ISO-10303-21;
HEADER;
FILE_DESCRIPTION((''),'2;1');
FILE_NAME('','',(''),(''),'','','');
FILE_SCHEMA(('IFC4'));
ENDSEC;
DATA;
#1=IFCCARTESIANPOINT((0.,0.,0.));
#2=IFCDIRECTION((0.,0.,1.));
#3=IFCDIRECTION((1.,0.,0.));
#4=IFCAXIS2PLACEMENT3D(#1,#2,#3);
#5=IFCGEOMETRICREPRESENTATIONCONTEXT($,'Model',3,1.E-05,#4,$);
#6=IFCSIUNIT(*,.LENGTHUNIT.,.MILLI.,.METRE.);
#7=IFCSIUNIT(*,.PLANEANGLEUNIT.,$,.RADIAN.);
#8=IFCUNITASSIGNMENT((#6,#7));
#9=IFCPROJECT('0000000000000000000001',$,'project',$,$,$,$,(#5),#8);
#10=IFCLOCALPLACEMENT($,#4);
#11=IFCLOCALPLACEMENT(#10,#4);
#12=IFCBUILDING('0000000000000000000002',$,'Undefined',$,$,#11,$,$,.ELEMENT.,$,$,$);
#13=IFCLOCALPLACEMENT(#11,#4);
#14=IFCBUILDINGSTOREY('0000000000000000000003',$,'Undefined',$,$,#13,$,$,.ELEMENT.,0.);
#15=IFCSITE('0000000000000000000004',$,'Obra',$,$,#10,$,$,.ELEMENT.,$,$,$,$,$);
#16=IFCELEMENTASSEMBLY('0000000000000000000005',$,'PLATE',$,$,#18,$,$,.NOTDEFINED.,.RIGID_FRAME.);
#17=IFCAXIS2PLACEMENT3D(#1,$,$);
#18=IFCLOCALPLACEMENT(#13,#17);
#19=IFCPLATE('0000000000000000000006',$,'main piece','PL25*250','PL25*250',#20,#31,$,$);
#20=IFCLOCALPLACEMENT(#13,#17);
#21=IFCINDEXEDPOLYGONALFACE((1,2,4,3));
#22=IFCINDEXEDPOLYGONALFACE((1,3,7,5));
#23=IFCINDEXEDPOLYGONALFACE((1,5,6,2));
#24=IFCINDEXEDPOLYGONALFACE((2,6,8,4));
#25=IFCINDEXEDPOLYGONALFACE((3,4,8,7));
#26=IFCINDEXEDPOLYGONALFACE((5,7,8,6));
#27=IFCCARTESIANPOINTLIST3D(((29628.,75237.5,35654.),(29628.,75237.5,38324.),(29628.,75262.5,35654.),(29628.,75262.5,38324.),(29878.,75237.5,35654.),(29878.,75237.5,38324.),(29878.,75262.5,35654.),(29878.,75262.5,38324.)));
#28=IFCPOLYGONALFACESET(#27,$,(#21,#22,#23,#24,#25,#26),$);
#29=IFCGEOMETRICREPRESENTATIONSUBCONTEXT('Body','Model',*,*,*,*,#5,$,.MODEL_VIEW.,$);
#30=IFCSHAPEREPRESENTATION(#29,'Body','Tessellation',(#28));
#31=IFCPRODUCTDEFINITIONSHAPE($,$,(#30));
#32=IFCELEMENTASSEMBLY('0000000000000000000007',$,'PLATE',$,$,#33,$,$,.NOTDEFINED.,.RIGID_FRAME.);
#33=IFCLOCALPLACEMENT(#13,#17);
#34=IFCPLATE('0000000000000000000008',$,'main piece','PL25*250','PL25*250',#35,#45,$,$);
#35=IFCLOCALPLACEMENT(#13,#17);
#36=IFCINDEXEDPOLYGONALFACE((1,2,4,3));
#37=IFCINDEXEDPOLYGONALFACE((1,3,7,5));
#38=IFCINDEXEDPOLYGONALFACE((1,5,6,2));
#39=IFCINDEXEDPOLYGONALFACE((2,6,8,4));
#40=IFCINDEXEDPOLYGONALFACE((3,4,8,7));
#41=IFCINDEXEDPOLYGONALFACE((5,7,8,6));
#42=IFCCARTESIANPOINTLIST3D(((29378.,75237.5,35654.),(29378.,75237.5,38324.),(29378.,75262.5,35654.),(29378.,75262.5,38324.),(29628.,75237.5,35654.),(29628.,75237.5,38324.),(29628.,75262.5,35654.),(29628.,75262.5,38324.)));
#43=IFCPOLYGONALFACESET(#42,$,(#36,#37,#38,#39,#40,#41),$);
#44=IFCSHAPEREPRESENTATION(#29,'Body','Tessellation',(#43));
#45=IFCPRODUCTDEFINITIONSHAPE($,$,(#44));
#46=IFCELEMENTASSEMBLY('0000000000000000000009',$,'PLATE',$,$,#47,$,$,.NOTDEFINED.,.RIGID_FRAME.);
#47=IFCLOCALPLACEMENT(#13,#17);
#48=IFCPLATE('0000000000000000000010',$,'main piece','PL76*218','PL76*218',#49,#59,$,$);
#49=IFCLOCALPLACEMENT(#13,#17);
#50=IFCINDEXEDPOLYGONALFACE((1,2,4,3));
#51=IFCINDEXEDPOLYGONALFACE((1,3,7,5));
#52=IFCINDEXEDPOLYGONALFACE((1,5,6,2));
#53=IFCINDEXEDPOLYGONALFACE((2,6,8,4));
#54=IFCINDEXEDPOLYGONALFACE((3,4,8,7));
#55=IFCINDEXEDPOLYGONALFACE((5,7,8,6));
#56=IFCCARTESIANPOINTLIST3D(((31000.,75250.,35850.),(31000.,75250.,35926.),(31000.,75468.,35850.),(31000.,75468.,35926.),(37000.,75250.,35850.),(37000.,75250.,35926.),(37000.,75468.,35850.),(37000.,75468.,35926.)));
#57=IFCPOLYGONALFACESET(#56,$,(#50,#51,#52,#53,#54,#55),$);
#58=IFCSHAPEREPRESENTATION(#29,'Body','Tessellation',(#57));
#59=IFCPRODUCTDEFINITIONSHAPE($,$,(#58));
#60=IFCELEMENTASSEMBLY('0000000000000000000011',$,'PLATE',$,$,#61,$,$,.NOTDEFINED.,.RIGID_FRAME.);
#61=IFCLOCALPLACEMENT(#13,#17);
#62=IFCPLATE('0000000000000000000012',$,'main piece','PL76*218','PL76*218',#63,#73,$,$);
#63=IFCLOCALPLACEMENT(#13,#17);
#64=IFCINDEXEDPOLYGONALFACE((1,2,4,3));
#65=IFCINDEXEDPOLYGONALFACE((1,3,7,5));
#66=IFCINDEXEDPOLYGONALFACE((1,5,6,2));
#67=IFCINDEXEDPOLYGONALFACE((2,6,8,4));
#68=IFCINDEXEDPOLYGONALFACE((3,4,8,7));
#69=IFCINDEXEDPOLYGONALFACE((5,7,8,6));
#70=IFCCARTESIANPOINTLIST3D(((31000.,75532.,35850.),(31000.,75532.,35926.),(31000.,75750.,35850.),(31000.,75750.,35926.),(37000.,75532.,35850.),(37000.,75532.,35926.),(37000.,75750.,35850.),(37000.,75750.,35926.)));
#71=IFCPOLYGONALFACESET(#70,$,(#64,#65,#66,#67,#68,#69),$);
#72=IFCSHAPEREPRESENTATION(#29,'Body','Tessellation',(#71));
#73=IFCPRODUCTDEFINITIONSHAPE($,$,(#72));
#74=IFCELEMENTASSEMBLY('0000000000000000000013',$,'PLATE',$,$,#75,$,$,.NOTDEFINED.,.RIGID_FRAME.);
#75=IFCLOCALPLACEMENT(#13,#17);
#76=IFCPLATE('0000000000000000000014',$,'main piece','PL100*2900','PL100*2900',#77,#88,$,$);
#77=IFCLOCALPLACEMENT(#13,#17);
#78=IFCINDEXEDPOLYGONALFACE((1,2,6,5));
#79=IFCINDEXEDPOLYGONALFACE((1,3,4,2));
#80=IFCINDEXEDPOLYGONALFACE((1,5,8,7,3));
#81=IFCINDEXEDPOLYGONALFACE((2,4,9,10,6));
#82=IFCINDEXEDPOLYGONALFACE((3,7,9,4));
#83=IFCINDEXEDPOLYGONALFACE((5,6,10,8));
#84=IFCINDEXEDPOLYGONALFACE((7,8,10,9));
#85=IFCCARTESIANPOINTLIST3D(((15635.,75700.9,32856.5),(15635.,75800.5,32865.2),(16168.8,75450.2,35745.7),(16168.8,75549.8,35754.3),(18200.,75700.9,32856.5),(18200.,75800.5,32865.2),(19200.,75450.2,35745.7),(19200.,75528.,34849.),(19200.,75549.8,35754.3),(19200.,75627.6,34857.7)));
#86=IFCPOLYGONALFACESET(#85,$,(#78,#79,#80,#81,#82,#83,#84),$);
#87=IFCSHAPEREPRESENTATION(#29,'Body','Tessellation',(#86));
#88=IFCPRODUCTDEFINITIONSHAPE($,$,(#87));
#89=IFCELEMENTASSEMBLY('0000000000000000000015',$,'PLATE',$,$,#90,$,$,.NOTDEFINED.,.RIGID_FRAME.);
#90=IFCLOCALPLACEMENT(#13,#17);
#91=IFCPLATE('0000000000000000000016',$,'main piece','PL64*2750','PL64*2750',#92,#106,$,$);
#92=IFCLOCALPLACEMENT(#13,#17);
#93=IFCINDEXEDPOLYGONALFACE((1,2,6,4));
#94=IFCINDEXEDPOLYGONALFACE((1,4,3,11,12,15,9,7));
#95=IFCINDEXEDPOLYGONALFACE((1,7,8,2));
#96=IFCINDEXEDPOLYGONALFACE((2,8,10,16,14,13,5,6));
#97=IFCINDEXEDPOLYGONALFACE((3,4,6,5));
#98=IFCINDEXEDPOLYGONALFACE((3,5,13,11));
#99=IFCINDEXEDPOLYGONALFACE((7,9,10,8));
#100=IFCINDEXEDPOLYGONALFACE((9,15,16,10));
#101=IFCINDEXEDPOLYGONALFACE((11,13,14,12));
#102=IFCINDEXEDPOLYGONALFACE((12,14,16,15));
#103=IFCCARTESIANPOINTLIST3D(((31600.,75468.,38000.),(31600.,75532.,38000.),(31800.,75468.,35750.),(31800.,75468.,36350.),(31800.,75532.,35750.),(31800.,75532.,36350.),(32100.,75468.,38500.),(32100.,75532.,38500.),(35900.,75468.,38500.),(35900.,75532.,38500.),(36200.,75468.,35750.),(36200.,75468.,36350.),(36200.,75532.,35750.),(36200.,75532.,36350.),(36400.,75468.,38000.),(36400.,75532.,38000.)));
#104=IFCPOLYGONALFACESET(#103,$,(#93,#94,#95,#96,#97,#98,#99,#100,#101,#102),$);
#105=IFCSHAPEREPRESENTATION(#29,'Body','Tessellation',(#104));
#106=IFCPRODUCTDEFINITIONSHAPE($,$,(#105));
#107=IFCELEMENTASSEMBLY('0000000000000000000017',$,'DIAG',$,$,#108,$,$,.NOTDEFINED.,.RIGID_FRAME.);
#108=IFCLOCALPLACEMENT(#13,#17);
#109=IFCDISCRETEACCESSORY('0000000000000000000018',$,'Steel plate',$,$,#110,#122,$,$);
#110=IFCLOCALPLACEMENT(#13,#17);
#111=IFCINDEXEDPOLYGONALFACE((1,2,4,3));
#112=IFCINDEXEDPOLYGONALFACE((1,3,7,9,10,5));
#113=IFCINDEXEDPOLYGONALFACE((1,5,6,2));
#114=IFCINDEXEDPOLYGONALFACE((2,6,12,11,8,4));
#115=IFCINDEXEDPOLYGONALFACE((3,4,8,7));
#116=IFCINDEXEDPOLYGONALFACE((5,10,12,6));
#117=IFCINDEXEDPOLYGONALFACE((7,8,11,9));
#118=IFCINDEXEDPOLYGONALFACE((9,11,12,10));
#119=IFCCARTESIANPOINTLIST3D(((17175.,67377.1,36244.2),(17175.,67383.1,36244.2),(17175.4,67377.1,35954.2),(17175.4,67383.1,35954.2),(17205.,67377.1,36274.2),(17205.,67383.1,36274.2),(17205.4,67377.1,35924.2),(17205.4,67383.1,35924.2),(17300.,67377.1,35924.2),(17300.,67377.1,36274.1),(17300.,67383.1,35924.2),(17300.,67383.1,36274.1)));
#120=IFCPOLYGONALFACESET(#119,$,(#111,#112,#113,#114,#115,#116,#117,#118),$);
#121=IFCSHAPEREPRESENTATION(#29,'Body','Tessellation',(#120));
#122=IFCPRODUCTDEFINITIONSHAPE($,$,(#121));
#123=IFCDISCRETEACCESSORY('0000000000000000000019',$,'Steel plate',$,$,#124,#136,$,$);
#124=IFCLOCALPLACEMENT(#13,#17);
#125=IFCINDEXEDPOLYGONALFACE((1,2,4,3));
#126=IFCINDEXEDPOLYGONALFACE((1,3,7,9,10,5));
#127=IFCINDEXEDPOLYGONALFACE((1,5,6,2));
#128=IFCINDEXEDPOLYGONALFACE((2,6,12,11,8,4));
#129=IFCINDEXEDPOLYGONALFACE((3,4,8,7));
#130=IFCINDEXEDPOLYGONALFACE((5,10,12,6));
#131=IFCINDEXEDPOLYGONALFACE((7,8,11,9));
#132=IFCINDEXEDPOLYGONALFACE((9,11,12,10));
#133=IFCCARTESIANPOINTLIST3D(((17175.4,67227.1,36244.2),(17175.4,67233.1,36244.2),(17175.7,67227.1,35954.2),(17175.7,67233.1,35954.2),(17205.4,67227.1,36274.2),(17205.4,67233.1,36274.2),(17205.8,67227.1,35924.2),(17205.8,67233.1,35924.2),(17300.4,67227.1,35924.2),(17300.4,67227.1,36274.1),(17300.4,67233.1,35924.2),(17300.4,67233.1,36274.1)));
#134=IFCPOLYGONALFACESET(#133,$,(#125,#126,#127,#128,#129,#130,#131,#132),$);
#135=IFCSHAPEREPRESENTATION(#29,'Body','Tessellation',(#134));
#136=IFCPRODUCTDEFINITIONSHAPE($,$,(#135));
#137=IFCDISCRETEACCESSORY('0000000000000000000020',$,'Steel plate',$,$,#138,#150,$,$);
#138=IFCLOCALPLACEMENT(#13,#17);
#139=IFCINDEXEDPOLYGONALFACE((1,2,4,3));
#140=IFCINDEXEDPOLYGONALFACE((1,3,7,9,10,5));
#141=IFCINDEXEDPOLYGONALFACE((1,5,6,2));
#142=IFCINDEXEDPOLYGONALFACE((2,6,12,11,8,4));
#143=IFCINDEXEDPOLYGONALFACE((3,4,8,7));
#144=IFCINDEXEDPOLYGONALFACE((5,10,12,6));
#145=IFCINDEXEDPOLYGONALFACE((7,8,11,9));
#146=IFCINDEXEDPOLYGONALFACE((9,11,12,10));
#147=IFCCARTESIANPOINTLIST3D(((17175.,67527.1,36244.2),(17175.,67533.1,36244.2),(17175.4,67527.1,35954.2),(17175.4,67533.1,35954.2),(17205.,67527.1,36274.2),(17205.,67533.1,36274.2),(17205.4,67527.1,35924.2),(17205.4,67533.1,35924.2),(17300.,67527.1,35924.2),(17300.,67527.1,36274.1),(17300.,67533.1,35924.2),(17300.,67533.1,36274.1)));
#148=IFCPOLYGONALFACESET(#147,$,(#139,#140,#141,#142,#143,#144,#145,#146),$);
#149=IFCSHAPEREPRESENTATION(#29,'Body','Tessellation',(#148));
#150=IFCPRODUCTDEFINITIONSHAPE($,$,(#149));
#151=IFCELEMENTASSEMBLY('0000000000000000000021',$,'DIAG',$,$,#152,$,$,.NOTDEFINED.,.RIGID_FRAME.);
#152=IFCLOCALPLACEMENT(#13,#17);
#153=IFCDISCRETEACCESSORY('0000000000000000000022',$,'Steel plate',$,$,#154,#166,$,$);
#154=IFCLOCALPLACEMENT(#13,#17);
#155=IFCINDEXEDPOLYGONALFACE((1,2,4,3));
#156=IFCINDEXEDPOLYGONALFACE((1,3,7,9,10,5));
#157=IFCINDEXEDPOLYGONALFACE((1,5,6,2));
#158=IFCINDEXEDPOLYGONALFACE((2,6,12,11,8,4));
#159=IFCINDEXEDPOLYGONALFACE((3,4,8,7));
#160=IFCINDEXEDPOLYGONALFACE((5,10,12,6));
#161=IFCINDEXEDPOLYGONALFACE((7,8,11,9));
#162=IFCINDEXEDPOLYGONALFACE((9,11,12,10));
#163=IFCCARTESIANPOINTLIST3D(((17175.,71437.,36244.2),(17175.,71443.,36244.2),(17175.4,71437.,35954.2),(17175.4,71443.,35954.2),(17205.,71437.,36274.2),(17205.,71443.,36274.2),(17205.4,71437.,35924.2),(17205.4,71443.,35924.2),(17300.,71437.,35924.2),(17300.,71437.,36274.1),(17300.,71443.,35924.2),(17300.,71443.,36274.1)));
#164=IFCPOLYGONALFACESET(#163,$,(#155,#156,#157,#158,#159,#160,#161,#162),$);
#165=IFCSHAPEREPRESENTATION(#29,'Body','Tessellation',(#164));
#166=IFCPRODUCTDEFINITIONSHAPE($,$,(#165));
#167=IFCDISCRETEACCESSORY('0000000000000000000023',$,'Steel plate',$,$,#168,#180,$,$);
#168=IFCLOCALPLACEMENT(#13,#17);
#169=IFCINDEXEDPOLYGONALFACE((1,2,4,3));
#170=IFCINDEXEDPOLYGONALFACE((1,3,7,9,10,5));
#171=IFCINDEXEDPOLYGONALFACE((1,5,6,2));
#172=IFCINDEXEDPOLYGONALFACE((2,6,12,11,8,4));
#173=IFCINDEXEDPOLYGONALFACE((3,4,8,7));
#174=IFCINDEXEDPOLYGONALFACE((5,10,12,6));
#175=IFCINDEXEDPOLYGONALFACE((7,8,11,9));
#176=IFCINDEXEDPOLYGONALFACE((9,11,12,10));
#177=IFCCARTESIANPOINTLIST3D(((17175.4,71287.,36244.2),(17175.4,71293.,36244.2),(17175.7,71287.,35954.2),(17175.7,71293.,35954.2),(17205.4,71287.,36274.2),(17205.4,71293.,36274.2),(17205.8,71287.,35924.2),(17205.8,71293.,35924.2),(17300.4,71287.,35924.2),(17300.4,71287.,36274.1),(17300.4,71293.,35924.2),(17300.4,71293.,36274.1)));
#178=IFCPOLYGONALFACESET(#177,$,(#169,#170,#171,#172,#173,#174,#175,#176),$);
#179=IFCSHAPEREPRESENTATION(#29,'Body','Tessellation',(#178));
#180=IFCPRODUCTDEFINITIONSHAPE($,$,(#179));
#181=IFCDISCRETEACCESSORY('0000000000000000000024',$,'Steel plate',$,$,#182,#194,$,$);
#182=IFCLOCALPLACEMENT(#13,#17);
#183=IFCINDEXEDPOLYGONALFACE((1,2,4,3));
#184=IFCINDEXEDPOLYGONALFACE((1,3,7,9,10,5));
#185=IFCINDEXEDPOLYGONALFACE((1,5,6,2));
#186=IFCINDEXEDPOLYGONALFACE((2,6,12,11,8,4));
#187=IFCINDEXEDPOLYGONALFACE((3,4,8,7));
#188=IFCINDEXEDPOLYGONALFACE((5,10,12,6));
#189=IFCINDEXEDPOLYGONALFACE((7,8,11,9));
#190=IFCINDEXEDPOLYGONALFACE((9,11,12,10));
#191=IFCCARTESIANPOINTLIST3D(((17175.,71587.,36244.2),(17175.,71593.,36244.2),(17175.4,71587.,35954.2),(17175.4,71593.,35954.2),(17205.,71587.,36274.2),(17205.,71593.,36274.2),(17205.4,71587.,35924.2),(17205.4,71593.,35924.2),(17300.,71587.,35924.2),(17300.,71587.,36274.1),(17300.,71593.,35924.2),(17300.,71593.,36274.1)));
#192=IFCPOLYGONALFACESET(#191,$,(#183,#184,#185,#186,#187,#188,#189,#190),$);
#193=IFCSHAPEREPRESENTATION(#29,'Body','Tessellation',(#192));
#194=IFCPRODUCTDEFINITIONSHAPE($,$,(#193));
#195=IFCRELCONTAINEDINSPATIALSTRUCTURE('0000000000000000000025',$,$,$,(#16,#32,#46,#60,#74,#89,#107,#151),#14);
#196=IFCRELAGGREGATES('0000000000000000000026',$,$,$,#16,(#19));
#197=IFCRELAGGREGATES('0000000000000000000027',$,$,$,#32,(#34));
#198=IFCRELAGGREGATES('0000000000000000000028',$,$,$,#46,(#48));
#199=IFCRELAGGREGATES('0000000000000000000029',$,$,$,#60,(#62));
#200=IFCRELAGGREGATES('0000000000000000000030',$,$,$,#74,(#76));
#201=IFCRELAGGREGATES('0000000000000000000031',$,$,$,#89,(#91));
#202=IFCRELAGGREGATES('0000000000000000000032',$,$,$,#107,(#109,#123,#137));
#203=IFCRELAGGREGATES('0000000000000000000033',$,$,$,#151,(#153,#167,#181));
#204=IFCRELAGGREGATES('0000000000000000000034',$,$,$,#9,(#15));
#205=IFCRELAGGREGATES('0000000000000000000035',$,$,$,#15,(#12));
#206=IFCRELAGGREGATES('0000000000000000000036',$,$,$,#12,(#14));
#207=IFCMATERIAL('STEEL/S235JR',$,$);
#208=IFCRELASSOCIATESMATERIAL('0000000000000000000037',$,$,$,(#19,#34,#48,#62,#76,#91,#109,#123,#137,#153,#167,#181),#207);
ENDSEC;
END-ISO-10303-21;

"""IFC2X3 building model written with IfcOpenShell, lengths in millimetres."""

from ifc_helpers import new_model, si_unit, frame, origin_with_axes, place, context, subcontext, project, spatial, polyline, outline, extrude, material, element, aggregate, save


model = new_model("IFC2X3")

# Units and contexts
model_context = context("Model", 3, precision=1e-05, world=origin_with_axes())
body_context = subcontext(model_context, "Body", "Model", "MODEL_VIEW")
ifc_project = project(units=[si_unit("LENGTHUNIT", "METRE", prefix="MILLI"), si_unit("PLANEANGLEUNIT", "RADIAN")], contexts=[model_context])

# Site, building, storey
site_placement = place(None, origin_with_axes())
site = spatial("IfcSite", under=ifc_project, at=site_placement, Name="Obra", CompositionType="ELEMENT")
building_placement = place(site_placement, origin_with_axes())
building = spatial("IfcBuilding", under=site, at=building_placement, Name="Undefined", CompositionType="ELEMENT")
storey_placement = place(building_placement, origin_with_axes())
storey = spatial("IfcBuildingStorey", under=building, at=storey_placement, Name="Undefined", CompositionType="ELEMENT", Elevation=0.0)

# Shared definitions
ifc_material = material(Name="STEEL/S235JR")

# Element assemblies, plates
assembly_1_placement = place(storey_placement, origin_with_axes())
assembly_1 = element("IfcElementAssembly", 1, at=assembly_1_placement, inside=storey, Name="PLATE", AssemblyPlace="NOTDEFINED", PredefinedType="RIGID_FRAME")
plate_1_placement = place(assembly_1_placement, frame((29628.0, 75250.0, 35654.0), z_axis=(0.0, -1.0, 0.0), x_axis=(1.0, 0.0, 0.0)))
plate_1 = element("IfcPlate", 2, at=plate_1_placement, material=ifc_material, Name="main piece", Description="PL25*250", ObjectType="PL25*250", context=body_context, shape_type="SweptSolid", body=[
    extrude(outline(polyline([(0.0, 0.0), (250.0, 0.0), (250.0, 2670.0), (0.0, 2670.0), (0.0, 0.0)])), frame((0.0, 0.0, -12.5), z_axis=(0.0, 0.0, 1.0), x_axis=(1.0, 0.0, 0.0)), (0.0, 0.0, 1.0), 25.0),
])
aggregate(assembly_1, [plate_1])
assembly_2_placement = place(storey_placement, origin_with_axes())
assembly_2 = element("IfcElementAssembly", 3, at=assembly_2_placement, inside=storey, Name="PLATE", AssemblyPlace="NOTDEFINED", PredefinedType="RIGID_FRAME")
plate_2_placement = place(assembly_2_placement, frame((29378.0, 75250.0, 35654.0), z_axis=(0.0, -1.0, 0.0), x_axis=(1.0, 0.0, 0.0)))
plate_2 = element("IfcPlate", 4, at=plate_2_placement, material=ifc_material, Name="main piece", Description="PL25*250", ObjectType="PL25*250", context=body_context, shape_type="SweptSolid", body=[
    extrude(outline(polyline([(0.0, 0.0), (250.0, 0.0), (250.0, 2670.0), (0.0, 2670.0), (0.0, 0.0)])), frame((0.0, 0.0, -12.5), z_axis=(0.0, 0.0, 1.0), x_axis=(1.0, 0.0, 0.0)), (0.0, 0.0, 1.0), 25.0),
])
aggregate(assembly_2, [plate_2])
assembly_3_placement = place(storey_placement, origin_with_axes())
assembly_3 = element("IfcElementAssembly", 5, at=assembly_3_placement, inside=storey, Name="PLATE", AssemblyPlace="NOTDEFINED", PredefinedType="RIGID_FRAME")
plate_3_placement = place(assembly_3_placement, frame((31000.0, 75250.0, 35888.0), z_axis=(0.0, 0.0, -1.0), x_axis=(0.0, 1.0, 0.0)))
plate_3 = element("IfcPlate", 6, at=plate_3_placement, material=ifc_material, Name="main piece", Description="PL76*218", ObjectType="PL76*218", context=body_context, shape_type="SweptSolid", body=[
    extrude(outline(polyline([(0.0, 0.0), (218.0, 0.0), (218.0, 6000.0), (0.0, 6000.0), (0.0, 0.0)])), frame((0.0, 0.0, -38.0), z_axis=(0.0, 0.0, 1.0), x_axis=(1.0, 0.0, 0.0)), (0.0, 0.0, 1.0), 76.0),
])
aggregate(assembly_3, [plate_3])
assembly_4_placement = place(storey_placement, origin_with_axes())
assembly_4 = element("IfcElementAssembly", 7, at=assembly_4_placement, inside=storey, Name="PLATE", AssemblyPlace="NOTDEFINED", PredefinedType="RIGID_FRAME")
plate_4_placement = place(assembly_4_placement, frame((31000.0, 75750.0, 35888.0), z_axis=(0.0, 0.0, 1.0), x_axis=(0.0, -1.0, 0.0)))
plate_4 = element("IfcPlate", 8, at=plate_4_placement, material=ifc_material, Name="main piece", Description="PL76*218", ObjectType="PL76*218", context=body_context, shape_type="SweptSolid", body=[
    extrude(outline(polyline([(0.0, 0.0), (218.0, 0.0), (218.0, 6000.0), (0.0, 6000.0), (0.0, 0.0)])), frame((0.0, 0.0, -38.0), z_axis=(0.0, 0.0, 1.0), x_axis=(1.0, 0.0, 0.0)), (0.0, 0.0, 1.0), 76.0),
])
aggregate(assembly_4, [plate_4])
assembly_5_placement = place(storey_placement, origin_with_axes())
assembly_5 = element("IfcElementAssembly", 9, at=assembly_5_placement, inside=storey, Name="PLATE", AssemblyPlace="NOTDEFINED", PredefinedType="RIGID_FRAME")
plate_5_placement = place(assembly_5_placement, frame((19200.0, 75500.0, 35750.0), z_axis=(0.0, -0.996255, -0.08646), x_axis=(-1.0, 0.0, 0.0)))
plate_5 = element("IfcPlate", 10, at=plate_5_placement, material=ifc_material, Name="main piece", Description="PL100*2900", ObjectType="PL100*2900", context=body_context, shape_type="SweptSolid", body=[
    extrude(outline(polyline([(0.0, 0.0), (3031.2, 0.0), (3565.0, 2900.0), (1000.0, 2900.0), (0.0, 900.0), (0.0, 0.0)])), frame((0.0, 0.0, -50.0), z_axis=(0.0, 0.0, 1.0), x_axis=(1.0, 0.0, 0.0)), (0.0, 0.0, 1.0), 100.0),
])
aggregate(assembly_5, [plate_5])
assembly_6_placement = place(storey_placement, origin_with_axes())
assembly_6 = element("IfcElementAssembly", 11, at=assembly_6_placement, inside=storey, Name="PLATE", AssemblyPlace="NOTDEFINED", PredefinedType="RIGID_FRAME")
plate_6_placement = place(assembly_6_placement, frame((31800.0, 75500.0, 35750.0), z_axis=(0.0, -1.0, 0.0), x_axis=(1.0, 0.0, 0.0)))
plate_6 = element("IfcPlate", 12, at=plate_6_placement, material=ifc_material, Name="main piece", Description="PL64*2750", ObjectType="PL64*2750", context=body_context, shape_type="SweptSolid", body=[
    extrude(outline(polyline([(0.0, 0.0), (4400.0, 0.0), (4400.0, 600.0), (4600.0, 2250.0), (4100.0, 2750.0), (300.0, 2750.0), (-200.0, 2250.0), (0.0, 600.0), (0.0, 0.0)])), frame((0.0, 0.0, -32.0), z_axis=(0.0, 0.0, 1.0), x_axis=(1.0, 0.0, 0.0)), (0.0, 0.0, 1.0), 64.0),
])
aggregate(assembly_6, [plate_6])

# Element assemblies, discrete accessories
assembly_7_placement = place(storey_placement, origin_with_axes())
assembly_7 = element("IfcElementAssembly", 13, at=assembly_7_placement, inside=storey, Name="DIAG", AssemblyPlace="NOTDEFINED", PredefinedType="RIGID_FRAME")
discrete_accessory_1_placement = place(assembly_7_placement, frame((17300.0, 67380.1, 35924.2), z_axis=(0.0, 1.0, 0.0), x_axis=(-1.0, 0.0, 0.0)))
discrete_accessory_1 = element("IfcDiscreteAccessory", 14, at=discrete_accessory_1_placement, material=ifc_material, Name="Steel plate", context=body_context, shape_type="SweptSolid", body=[
    extrude(outline(polyline([(0.0, 0.0), (94.6, 0.0), (124.6, 30.0), (125.0, 320.0), (95.0, 350.0), (0.0, 349.9), (0.0, 0.0)])), frame((0.0, 0.0, -3.0), z_axis=(0.0, 0.0, 1.0), x_axis=(1.0, 0.0, 0.0)), (0.0, 0.0, 1.0), 6.0),
])
discrete_accessory_2_placement = place(assembly_7_placement, frame((17300.4, 67230.1, 35924.2), z_axis=(0.0, 1.0, 0.0), x_axis=(-1.0, 0.0, 0.0)))
discrete_accessory_2 = element("IfcDiscreteAccessory", 15, at=discrete_accessory_2_placement, material=ifc_material, Name="Steel plate", context=body_context, shape_type="SweptSolid", body=[
    extrude(outline(polyline([(0.0, 0.0), (94.6, 0.0), (124.6, 30.0), (125.0, 320.0), (95.0, 350.0), (0.0, 349.9), (0.0, 0.0)])), frame((0.0, 0.0, -3.0), z_axis=(0.0, 0.0, 1.0), x_axis=(1.0, 0.0, 0.0)), (0.0, 0.0, 1.0), 6.0),
])
discrete_accessory_3_placement = place(assembly_7_placement, frame((17300.0, 67530.1, 35924.2), z_axis=(0.0, 1.0, 0.0), x_axis=(-1.0, 0.0, 0.0)))
discrete_accessory_3 = element("IfcDiscreteAccessory", 16, at=discrete_accessory_3_placement, material=ifc_material, Name="Steel plate", context=body_context, shape_type="SweptSolid", body=[
    extrude(outline(polyline([(0.0, 0.0), (94.6, 0.0), (124.6, 30.0), (125.0, 320.0), (95.0, 350.0), (0.0, 349.9), (0.0, 0.0)])), frame((0.0, 0.0, -3.0), z_axis=(0.0, 0.0, 1.0), x_axis=(1.0, 0.0, 0.0)), (0.0, 0.0, 1.0), 6.0),
])
aggregate(assembly_7, [discrete_accessory_1, discrete_accessory_2, discrete_accessory_3])
assembly_8_placement = place(storey_placement, origin_with_axes())
assembly_8 = element("IfcElementAssembly", 17, at=assembly_8_placement, inside=storey, Name="DIAG", AssemblyPlace="NOTDEFINED", PredefinedType="RIGID_FRAME")
discrete_accessory_4_placement = place(assembly_8_placement, frame((17300.0, 71440.0, 35924.2), z_axis=(0.0, 1.0, 0.0), x_axis=(-1.0, 0.0, 0.0)))
discrete_accessory_4 = element("IfcDiscreteAccessory", 18, at=discrete_accessory_4_placement, material=ifc_material, Name="Steel plate", context=body_context, shape_type="SweptSolid", body=[
    extrude(outline(polyline([(0.0, 0.0), (94.6, 0.0), (124.6, 30.0), (125.0, 320.0), (95.0, 350.0), (0.0, 349.9), (0.0, 0.0)])), frame((0.0, 0.0, -3.0), z_axis=(0.0, 0.0, 1.0), x_axis=(1.0, 0.0, 0.0)), (0.0, 0.0, 1.0), 6.0),
])
discrete_accessory_5_placement = place(assembly_8_placement, frame((17300.4, 71290.0, 35924.2), z_axis=(0.0, 1.0, 0.0), x_axis=(-1.0, 0.0, 0.0)))
discrete_accessory_5 = element("IfcDiscreteAccessory", 19, at=discrete_accessory_5_placement, material=ifc_material, Name="Steel plate", context=body_context, shape_type="SweptSolid", body=[
    extrude(outline(polyline([(0.0, 0.0), (94.6, 0.0), (124.6, 30.0), (125.0, 320.0), (95.0, 350.0), (0.0, 349.9), (0.0, 0.0)])), frame((0.0, 0.0, -3.0), z_axis=(0.0, 0.0, 1.0), x_axis=(1.0, 0.0, 0.0)), (0.0, 0.0, 1.0), 6.0),
])
discrete_accessory_6_placement = place(assembly_8_placement, frame((17300.0, 71590.0, 35924.2), z_axis=(0.0, 1.0, 0.0), x_axis=(-1.0, 0.0, 0.0)))
discrete_accessory_6 = element("IfcDiscreteAccessory", 20, at=discrete_accessory_6_placement, material=ifc_material, Name="Steel plate", context=body_context, shape_type="SweptSolid", body=[
    extrude(outline(polyline([(0.0, 0.0), (94.6, 0.0), (124.6, 30.0), (125.0, 320.0), (95.0, 350.0), (0.0, 349.9), (0.0, 0.0)])), frame((0.0, 0.0, -3.0), z_axis=(0.0, 0.0, 1.0), x_axis=(1.0, 0.0, 0.0)), (0.0, 0.0, 1.0), 6.0),
])
aggregate(assembly_8, [discrete_accessory_4, discrete_accessory_5, discrete_accessory_6])

save(model, "model.ifc")
